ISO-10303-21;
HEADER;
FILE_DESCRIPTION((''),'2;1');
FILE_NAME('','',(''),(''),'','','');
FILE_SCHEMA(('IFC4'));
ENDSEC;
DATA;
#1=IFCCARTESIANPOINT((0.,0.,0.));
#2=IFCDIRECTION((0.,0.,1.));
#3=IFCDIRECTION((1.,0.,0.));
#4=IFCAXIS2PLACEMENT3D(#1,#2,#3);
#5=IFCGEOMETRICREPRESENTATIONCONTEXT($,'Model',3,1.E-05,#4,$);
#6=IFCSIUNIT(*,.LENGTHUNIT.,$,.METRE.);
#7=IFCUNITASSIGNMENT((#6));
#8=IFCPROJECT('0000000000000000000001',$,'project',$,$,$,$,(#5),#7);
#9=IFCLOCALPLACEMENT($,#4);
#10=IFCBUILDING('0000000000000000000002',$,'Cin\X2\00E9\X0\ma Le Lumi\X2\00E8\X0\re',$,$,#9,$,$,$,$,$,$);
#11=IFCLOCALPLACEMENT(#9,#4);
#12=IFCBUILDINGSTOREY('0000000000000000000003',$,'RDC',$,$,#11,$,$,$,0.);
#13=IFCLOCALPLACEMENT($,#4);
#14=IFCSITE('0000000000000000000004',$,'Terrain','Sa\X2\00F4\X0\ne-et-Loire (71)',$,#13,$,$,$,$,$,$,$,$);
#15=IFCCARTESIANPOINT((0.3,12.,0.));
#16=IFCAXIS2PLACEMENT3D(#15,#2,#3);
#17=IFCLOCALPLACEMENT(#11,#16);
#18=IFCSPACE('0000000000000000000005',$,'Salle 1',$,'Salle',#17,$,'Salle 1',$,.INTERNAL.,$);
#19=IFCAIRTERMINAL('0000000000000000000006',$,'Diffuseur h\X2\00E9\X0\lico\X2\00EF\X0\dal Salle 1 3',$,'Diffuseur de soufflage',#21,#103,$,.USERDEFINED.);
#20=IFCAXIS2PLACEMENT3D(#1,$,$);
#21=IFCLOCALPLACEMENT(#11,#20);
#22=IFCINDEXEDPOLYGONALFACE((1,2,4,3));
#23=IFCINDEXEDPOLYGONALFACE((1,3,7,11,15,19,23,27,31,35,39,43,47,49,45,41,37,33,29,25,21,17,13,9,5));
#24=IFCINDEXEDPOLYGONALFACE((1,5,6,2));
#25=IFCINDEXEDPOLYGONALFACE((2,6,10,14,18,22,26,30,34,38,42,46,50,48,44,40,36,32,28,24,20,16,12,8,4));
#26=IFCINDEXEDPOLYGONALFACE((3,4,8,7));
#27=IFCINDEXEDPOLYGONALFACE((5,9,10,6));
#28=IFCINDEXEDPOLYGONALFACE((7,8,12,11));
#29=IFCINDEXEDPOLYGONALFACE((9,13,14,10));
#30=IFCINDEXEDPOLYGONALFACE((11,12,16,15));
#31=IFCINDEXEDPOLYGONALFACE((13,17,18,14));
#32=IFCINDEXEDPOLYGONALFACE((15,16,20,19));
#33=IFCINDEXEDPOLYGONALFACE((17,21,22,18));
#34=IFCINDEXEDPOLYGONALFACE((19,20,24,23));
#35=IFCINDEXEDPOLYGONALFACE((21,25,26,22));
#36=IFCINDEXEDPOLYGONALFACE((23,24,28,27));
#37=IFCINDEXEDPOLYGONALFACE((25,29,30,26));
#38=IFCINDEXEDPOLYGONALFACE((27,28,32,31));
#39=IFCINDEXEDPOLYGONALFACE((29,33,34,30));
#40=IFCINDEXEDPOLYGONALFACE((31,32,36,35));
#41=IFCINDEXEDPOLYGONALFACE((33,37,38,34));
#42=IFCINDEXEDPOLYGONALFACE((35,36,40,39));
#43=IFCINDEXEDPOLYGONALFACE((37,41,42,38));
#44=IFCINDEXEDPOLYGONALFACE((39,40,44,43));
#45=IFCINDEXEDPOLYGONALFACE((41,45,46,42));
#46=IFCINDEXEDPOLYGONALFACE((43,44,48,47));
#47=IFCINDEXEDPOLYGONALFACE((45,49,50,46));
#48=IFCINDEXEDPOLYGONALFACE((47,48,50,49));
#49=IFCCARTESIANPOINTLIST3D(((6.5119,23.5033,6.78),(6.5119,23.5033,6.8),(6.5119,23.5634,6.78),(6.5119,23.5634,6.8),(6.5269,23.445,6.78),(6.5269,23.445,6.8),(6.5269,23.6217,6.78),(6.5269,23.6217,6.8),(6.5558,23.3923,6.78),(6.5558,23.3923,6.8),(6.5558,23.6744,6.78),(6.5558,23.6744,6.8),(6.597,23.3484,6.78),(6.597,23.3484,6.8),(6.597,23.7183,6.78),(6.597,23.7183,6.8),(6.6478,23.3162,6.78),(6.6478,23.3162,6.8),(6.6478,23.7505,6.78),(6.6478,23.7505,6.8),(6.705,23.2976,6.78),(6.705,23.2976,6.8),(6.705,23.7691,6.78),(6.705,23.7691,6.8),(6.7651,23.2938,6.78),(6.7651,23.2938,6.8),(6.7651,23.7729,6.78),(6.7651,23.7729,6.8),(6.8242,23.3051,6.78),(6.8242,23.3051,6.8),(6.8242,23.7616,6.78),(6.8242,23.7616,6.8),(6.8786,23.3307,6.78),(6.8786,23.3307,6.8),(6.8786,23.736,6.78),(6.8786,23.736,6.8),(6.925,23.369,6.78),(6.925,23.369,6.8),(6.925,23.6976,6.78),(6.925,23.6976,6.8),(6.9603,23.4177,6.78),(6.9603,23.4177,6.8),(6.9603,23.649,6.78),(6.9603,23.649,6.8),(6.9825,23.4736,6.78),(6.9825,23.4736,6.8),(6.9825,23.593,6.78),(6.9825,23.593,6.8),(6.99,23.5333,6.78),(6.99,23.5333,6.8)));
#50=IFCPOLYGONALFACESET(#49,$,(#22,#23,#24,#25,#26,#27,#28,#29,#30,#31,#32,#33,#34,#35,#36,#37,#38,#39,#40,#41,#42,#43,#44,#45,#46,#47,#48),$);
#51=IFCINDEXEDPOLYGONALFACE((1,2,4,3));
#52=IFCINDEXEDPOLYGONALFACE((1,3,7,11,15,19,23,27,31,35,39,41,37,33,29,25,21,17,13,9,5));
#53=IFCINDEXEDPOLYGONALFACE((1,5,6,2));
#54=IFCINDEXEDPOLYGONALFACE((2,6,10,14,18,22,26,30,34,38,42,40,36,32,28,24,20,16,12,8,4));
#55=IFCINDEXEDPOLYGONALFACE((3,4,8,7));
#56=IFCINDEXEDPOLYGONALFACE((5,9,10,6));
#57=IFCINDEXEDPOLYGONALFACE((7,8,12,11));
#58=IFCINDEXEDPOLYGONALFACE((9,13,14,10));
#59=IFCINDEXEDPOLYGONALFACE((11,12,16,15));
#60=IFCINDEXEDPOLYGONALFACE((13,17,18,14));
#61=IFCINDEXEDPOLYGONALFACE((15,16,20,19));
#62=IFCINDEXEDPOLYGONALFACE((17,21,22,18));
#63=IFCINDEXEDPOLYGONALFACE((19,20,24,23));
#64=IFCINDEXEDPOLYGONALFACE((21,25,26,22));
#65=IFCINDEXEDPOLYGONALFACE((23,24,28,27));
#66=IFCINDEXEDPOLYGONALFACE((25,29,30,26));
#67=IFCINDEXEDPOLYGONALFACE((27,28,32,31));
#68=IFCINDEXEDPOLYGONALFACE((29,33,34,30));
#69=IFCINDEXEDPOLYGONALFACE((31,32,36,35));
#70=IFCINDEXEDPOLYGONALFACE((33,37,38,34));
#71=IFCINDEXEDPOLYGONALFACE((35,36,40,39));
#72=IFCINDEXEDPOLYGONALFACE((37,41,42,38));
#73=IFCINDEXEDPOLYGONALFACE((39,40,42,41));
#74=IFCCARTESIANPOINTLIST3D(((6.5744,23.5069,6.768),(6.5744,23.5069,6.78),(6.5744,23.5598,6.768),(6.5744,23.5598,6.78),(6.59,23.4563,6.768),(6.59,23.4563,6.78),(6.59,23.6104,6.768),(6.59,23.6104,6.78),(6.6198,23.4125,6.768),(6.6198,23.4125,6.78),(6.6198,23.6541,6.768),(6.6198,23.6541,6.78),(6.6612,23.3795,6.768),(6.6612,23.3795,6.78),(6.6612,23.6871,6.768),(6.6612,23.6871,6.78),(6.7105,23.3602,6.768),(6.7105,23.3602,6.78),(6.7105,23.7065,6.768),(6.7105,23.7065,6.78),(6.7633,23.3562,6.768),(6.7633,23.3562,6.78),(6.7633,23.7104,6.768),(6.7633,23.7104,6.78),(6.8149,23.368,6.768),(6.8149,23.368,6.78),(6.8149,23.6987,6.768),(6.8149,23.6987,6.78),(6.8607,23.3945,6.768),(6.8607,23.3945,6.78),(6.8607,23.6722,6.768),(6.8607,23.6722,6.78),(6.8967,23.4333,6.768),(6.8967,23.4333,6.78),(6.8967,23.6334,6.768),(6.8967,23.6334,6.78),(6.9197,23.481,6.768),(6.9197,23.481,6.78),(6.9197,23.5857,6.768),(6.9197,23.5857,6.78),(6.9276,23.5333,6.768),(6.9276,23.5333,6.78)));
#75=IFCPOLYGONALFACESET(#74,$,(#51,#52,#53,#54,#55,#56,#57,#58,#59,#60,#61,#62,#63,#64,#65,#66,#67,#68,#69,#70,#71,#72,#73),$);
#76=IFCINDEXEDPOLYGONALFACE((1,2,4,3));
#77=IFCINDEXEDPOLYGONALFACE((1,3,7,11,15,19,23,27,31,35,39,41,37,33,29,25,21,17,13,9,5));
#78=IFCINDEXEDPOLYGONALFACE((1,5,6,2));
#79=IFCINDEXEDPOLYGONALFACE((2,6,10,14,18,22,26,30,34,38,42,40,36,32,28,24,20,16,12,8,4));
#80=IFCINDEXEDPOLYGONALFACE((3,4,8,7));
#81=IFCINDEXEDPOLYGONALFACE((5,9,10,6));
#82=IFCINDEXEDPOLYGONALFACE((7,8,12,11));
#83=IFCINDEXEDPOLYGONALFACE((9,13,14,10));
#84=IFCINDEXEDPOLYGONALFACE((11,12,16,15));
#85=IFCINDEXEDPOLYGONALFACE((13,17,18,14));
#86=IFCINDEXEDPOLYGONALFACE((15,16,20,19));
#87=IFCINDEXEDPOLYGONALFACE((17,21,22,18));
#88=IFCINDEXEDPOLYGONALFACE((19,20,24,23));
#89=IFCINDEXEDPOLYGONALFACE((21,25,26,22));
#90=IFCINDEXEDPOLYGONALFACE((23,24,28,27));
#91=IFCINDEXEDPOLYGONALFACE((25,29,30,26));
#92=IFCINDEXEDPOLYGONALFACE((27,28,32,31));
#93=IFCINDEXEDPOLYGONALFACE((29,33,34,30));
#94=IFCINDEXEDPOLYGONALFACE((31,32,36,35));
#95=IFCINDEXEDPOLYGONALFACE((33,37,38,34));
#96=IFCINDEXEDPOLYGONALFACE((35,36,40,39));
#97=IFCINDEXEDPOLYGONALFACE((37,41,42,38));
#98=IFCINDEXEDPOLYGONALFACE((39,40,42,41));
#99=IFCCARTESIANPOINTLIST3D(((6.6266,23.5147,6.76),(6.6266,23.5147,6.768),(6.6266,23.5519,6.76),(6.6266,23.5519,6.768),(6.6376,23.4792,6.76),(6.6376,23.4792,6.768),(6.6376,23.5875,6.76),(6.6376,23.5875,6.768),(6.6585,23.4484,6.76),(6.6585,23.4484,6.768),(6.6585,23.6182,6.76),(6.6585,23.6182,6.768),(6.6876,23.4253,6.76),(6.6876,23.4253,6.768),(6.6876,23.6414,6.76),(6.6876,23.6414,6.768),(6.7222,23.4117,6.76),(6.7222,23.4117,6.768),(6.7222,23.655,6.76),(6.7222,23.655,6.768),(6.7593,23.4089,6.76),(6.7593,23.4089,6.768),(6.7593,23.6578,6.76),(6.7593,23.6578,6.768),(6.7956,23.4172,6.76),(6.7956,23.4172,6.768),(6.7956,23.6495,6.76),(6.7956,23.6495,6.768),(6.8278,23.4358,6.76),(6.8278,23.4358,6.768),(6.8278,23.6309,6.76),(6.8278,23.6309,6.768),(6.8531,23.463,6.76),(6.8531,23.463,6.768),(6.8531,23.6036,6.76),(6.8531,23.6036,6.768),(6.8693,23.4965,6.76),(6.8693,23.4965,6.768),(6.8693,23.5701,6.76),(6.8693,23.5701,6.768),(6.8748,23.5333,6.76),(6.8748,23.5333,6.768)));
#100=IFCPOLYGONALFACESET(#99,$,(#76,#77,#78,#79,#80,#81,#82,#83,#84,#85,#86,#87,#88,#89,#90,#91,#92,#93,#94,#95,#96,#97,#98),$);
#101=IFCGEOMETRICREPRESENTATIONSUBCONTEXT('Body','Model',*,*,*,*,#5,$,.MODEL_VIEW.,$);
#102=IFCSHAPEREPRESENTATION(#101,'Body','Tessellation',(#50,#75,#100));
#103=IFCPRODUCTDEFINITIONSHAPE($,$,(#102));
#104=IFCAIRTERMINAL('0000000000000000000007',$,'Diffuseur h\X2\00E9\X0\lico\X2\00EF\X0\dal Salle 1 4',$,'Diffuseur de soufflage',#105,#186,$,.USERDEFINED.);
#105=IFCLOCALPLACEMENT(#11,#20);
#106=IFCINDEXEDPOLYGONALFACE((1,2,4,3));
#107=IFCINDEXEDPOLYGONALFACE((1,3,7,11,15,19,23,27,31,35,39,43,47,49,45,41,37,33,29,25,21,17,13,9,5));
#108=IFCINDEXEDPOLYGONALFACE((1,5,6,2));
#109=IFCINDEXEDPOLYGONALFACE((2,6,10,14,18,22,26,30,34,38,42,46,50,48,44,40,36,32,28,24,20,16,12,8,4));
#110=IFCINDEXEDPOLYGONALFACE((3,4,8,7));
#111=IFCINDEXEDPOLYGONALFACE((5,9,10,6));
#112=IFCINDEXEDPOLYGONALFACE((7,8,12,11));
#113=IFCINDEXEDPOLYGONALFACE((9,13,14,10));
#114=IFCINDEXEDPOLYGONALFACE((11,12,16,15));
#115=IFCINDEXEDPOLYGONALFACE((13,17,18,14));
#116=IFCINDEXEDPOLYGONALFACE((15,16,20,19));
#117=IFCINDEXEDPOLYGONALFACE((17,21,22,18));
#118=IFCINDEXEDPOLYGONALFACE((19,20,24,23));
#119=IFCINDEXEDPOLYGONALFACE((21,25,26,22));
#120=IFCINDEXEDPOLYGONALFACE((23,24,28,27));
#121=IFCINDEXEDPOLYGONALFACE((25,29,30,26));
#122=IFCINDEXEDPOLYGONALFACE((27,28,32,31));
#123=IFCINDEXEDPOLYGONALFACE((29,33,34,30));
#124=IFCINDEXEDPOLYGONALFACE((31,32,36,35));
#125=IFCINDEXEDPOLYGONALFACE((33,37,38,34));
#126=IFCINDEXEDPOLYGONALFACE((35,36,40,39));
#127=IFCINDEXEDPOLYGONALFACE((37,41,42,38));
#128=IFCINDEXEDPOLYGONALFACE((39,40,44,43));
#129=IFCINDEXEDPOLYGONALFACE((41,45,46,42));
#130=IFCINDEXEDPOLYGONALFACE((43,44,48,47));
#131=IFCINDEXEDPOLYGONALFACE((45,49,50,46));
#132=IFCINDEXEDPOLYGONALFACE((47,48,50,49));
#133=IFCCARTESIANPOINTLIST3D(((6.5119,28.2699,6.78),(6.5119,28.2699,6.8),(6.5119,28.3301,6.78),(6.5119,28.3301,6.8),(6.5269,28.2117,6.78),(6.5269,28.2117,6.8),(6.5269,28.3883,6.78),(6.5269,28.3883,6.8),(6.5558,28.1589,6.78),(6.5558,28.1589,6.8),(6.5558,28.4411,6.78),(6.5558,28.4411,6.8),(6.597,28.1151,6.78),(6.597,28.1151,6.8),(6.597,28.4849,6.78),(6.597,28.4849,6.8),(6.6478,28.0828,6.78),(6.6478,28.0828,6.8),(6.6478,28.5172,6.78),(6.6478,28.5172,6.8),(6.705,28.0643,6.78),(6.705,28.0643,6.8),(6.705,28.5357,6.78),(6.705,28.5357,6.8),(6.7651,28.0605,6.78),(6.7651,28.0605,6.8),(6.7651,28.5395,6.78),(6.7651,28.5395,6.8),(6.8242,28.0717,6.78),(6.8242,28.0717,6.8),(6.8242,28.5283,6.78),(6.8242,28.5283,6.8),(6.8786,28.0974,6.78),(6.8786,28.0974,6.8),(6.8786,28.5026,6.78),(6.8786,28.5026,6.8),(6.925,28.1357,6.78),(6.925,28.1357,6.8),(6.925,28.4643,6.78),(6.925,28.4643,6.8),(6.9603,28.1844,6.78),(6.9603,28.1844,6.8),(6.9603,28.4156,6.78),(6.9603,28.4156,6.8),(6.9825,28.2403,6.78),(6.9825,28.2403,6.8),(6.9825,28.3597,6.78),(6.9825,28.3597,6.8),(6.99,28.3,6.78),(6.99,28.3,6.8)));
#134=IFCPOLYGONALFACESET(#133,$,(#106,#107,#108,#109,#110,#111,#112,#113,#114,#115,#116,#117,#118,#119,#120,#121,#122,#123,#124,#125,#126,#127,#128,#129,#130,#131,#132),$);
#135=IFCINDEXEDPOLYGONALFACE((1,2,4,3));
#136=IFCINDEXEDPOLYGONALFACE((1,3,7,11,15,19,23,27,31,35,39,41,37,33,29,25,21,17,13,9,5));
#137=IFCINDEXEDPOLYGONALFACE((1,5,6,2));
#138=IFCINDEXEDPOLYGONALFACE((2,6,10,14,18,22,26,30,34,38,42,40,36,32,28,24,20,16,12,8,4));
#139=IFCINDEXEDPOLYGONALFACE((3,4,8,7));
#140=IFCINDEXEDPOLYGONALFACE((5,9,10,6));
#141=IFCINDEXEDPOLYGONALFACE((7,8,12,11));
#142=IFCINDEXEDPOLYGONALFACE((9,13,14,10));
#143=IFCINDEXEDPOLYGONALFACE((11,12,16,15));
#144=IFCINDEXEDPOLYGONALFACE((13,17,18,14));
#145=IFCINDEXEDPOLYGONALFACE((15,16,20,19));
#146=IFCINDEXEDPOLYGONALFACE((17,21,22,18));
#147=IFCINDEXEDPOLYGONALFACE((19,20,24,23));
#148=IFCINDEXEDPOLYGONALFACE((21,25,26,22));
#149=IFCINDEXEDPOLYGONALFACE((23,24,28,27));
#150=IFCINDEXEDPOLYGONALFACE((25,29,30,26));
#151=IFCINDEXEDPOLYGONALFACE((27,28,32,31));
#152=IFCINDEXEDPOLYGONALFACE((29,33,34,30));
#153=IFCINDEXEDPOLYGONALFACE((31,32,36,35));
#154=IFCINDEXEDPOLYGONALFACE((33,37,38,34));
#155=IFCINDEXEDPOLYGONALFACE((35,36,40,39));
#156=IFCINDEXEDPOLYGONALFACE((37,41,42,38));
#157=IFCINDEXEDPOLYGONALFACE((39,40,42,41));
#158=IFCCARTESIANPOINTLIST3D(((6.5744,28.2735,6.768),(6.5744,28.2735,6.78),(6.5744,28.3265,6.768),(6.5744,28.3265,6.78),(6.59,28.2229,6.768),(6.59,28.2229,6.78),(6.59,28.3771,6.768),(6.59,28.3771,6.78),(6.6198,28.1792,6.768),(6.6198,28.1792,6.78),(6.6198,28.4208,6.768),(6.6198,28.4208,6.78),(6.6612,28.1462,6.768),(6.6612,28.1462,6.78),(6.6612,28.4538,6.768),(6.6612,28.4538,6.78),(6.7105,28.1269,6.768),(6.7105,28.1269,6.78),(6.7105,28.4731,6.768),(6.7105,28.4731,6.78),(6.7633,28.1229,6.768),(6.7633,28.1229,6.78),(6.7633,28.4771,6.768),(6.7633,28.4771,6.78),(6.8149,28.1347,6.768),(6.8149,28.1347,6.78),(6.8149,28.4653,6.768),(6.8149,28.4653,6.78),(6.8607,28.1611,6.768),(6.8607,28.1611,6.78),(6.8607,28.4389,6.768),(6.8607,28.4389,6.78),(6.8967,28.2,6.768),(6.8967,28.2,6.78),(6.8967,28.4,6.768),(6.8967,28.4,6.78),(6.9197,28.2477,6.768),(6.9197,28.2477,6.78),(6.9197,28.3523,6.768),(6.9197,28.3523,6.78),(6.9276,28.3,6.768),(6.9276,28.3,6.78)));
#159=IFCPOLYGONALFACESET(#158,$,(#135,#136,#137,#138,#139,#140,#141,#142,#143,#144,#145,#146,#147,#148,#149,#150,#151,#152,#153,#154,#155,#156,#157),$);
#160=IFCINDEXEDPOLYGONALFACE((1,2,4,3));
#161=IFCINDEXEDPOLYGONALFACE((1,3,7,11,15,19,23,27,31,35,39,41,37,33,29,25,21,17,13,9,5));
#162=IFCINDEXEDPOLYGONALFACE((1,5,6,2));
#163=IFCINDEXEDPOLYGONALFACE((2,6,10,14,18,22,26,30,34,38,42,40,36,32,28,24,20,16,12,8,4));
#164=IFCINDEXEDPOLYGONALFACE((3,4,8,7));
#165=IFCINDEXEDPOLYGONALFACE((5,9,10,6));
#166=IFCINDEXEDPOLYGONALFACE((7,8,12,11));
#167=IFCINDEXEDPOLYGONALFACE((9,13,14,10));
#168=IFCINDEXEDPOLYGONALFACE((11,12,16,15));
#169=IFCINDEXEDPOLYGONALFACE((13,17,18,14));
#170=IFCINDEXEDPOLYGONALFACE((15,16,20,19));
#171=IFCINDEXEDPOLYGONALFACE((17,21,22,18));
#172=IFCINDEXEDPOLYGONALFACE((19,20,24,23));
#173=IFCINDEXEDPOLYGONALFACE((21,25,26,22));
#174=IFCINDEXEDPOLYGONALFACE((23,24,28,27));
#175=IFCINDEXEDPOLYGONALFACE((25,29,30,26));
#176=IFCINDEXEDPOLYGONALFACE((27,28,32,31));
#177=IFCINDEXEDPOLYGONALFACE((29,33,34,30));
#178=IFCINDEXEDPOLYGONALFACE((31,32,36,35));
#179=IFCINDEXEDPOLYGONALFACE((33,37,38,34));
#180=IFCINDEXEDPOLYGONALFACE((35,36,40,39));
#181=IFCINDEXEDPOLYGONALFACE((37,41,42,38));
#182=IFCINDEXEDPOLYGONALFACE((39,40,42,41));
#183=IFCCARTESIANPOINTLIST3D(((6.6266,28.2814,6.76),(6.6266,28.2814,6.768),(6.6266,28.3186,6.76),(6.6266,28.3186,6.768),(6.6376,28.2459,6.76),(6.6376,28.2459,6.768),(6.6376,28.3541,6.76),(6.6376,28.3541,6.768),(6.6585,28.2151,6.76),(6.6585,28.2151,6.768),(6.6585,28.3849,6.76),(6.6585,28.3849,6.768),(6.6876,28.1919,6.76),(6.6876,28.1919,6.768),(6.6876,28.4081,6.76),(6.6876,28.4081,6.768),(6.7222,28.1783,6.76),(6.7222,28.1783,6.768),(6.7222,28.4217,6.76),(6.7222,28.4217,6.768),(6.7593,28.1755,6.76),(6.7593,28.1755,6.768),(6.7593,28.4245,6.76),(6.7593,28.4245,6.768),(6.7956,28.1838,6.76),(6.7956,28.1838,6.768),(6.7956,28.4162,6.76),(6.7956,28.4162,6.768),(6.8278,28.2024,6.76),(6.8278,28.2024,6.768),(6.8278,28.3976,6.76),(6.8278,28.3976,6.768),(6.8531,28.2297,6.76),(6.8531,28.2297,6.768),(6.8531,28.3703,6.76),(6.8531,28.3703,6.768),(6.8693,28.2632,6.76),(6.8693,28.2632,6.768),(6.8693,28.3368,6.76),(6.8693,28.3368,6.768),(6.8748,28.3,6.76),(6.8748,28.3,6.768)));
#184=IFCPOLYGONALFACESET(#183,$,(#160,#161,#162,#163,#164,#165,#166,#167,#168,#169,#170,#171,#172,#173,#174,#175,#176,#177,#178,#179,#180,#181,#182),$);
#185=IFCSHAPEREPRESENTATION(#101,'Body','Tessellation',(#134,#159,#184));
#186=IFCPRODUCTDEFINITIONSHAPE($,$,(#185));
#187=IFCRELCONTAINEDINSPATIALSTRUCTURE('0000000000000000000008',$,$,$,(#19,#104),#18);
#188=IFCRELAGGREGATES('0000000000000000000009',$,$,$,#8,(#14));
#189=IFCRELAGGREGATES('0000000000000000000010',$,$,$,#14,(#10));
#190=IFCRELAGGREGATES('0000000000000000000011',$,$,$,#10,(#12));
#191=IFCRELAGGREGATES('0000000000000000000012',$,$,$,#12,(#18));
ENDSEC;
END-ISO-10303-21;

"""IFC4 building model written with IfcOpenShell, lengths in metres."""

from ifc_helpers import new_model, si_unit, frame, origin_with_axes, place, context, subcontext, project, spatial, circle, extrude, element, save


model = new_model("IFC4")

# Units and contexts
model_context = context("Model", 3, precision=1e-05, world=origin_with_axes())
body_context = subcontext(model_context, "Body", "Model", "MODEL_VIEW")
ifc_project = project(units=[si_unit("LENGTHUNIT", "METRE")], contexts=[model_context])

# Site, building, storey
site_placement = place(None, origin_with_axes())
site = spatial("IfcSite", under=ifc_project, at=site_placement, Name="Terrain", Description="Saône-et-Loire (71)")
building_placement = place(None, origin_with_axes())
building = spatial("IfcBuilding", under=site, at=building_placement, Name="Cinéma Le Lumière")
storey_placement = place(building_placement, origin_with_axes())
storey = spatial("IfcBuildingStorey", under=building, at=storey_placement, Name="RDC", Elevation=0.0)

# Shared definitions
space_1_placement = place(storey_placement, frame((0.3, 12.0, 0.0), z_axis=(0.0, 0.0, 1.0), x_axis=(1.0, 0.0, 0.0)))
space_1 = spatial("IfcSpace", under=storey, at=space_1_placement, Name="Salle 1", ObjectType="Salle", LongName="Salle 1", PredefinedType="INTERNAL")

# Air terminals
for number, where, z_axis, x_axis, name in (
    (1, (6.45, 11.5333, 6.76), (0.0, 0.0, 1.0), (1.0, 0.0, 0.0), "Diffuseur hélicoïdal Salle 1 3"),
    (2, (6.45, 16.3, 6.76), (0.0, 0.0, 1.0), (1.0, 0.0, 0.0), "Diffuseur hélicoïdal Salle 1 4"),
):
    element("IfcAirTerminal", number, at=place(space_1_placement, frame(where, z_axis=z_axis, x_axis=x_axis)), inside=space_1, Name=name, ObjectType="Diffuseur de soufflage", PredefinedType="USERDEFINED", context=body_context, shape_type="SweptSolid", body=[
        extrude(circle(Radius=0.24), frame((0.0, 0.0, 0.02), z_axis=(0.0, 0.0, 1.0), x_axis=(1.0, 0.0, 0.0)), (0.0, 0.0, 1.0), 0.02),
        extrude(circle(Radius=0.1776), frame((0.0, 0.0, 0.008), z_axis=(0.0, 0.0, 1.0), x_axis=(1.0, 0.0, 0.0)), (0.0, 0.0, 1.0), 0.012),
        extrude(circle(Radius=0.1248), origin_with_axes(), (0.0, 0.0, 1.0), 0.008),
    ])

save(model, "model.ifc")
